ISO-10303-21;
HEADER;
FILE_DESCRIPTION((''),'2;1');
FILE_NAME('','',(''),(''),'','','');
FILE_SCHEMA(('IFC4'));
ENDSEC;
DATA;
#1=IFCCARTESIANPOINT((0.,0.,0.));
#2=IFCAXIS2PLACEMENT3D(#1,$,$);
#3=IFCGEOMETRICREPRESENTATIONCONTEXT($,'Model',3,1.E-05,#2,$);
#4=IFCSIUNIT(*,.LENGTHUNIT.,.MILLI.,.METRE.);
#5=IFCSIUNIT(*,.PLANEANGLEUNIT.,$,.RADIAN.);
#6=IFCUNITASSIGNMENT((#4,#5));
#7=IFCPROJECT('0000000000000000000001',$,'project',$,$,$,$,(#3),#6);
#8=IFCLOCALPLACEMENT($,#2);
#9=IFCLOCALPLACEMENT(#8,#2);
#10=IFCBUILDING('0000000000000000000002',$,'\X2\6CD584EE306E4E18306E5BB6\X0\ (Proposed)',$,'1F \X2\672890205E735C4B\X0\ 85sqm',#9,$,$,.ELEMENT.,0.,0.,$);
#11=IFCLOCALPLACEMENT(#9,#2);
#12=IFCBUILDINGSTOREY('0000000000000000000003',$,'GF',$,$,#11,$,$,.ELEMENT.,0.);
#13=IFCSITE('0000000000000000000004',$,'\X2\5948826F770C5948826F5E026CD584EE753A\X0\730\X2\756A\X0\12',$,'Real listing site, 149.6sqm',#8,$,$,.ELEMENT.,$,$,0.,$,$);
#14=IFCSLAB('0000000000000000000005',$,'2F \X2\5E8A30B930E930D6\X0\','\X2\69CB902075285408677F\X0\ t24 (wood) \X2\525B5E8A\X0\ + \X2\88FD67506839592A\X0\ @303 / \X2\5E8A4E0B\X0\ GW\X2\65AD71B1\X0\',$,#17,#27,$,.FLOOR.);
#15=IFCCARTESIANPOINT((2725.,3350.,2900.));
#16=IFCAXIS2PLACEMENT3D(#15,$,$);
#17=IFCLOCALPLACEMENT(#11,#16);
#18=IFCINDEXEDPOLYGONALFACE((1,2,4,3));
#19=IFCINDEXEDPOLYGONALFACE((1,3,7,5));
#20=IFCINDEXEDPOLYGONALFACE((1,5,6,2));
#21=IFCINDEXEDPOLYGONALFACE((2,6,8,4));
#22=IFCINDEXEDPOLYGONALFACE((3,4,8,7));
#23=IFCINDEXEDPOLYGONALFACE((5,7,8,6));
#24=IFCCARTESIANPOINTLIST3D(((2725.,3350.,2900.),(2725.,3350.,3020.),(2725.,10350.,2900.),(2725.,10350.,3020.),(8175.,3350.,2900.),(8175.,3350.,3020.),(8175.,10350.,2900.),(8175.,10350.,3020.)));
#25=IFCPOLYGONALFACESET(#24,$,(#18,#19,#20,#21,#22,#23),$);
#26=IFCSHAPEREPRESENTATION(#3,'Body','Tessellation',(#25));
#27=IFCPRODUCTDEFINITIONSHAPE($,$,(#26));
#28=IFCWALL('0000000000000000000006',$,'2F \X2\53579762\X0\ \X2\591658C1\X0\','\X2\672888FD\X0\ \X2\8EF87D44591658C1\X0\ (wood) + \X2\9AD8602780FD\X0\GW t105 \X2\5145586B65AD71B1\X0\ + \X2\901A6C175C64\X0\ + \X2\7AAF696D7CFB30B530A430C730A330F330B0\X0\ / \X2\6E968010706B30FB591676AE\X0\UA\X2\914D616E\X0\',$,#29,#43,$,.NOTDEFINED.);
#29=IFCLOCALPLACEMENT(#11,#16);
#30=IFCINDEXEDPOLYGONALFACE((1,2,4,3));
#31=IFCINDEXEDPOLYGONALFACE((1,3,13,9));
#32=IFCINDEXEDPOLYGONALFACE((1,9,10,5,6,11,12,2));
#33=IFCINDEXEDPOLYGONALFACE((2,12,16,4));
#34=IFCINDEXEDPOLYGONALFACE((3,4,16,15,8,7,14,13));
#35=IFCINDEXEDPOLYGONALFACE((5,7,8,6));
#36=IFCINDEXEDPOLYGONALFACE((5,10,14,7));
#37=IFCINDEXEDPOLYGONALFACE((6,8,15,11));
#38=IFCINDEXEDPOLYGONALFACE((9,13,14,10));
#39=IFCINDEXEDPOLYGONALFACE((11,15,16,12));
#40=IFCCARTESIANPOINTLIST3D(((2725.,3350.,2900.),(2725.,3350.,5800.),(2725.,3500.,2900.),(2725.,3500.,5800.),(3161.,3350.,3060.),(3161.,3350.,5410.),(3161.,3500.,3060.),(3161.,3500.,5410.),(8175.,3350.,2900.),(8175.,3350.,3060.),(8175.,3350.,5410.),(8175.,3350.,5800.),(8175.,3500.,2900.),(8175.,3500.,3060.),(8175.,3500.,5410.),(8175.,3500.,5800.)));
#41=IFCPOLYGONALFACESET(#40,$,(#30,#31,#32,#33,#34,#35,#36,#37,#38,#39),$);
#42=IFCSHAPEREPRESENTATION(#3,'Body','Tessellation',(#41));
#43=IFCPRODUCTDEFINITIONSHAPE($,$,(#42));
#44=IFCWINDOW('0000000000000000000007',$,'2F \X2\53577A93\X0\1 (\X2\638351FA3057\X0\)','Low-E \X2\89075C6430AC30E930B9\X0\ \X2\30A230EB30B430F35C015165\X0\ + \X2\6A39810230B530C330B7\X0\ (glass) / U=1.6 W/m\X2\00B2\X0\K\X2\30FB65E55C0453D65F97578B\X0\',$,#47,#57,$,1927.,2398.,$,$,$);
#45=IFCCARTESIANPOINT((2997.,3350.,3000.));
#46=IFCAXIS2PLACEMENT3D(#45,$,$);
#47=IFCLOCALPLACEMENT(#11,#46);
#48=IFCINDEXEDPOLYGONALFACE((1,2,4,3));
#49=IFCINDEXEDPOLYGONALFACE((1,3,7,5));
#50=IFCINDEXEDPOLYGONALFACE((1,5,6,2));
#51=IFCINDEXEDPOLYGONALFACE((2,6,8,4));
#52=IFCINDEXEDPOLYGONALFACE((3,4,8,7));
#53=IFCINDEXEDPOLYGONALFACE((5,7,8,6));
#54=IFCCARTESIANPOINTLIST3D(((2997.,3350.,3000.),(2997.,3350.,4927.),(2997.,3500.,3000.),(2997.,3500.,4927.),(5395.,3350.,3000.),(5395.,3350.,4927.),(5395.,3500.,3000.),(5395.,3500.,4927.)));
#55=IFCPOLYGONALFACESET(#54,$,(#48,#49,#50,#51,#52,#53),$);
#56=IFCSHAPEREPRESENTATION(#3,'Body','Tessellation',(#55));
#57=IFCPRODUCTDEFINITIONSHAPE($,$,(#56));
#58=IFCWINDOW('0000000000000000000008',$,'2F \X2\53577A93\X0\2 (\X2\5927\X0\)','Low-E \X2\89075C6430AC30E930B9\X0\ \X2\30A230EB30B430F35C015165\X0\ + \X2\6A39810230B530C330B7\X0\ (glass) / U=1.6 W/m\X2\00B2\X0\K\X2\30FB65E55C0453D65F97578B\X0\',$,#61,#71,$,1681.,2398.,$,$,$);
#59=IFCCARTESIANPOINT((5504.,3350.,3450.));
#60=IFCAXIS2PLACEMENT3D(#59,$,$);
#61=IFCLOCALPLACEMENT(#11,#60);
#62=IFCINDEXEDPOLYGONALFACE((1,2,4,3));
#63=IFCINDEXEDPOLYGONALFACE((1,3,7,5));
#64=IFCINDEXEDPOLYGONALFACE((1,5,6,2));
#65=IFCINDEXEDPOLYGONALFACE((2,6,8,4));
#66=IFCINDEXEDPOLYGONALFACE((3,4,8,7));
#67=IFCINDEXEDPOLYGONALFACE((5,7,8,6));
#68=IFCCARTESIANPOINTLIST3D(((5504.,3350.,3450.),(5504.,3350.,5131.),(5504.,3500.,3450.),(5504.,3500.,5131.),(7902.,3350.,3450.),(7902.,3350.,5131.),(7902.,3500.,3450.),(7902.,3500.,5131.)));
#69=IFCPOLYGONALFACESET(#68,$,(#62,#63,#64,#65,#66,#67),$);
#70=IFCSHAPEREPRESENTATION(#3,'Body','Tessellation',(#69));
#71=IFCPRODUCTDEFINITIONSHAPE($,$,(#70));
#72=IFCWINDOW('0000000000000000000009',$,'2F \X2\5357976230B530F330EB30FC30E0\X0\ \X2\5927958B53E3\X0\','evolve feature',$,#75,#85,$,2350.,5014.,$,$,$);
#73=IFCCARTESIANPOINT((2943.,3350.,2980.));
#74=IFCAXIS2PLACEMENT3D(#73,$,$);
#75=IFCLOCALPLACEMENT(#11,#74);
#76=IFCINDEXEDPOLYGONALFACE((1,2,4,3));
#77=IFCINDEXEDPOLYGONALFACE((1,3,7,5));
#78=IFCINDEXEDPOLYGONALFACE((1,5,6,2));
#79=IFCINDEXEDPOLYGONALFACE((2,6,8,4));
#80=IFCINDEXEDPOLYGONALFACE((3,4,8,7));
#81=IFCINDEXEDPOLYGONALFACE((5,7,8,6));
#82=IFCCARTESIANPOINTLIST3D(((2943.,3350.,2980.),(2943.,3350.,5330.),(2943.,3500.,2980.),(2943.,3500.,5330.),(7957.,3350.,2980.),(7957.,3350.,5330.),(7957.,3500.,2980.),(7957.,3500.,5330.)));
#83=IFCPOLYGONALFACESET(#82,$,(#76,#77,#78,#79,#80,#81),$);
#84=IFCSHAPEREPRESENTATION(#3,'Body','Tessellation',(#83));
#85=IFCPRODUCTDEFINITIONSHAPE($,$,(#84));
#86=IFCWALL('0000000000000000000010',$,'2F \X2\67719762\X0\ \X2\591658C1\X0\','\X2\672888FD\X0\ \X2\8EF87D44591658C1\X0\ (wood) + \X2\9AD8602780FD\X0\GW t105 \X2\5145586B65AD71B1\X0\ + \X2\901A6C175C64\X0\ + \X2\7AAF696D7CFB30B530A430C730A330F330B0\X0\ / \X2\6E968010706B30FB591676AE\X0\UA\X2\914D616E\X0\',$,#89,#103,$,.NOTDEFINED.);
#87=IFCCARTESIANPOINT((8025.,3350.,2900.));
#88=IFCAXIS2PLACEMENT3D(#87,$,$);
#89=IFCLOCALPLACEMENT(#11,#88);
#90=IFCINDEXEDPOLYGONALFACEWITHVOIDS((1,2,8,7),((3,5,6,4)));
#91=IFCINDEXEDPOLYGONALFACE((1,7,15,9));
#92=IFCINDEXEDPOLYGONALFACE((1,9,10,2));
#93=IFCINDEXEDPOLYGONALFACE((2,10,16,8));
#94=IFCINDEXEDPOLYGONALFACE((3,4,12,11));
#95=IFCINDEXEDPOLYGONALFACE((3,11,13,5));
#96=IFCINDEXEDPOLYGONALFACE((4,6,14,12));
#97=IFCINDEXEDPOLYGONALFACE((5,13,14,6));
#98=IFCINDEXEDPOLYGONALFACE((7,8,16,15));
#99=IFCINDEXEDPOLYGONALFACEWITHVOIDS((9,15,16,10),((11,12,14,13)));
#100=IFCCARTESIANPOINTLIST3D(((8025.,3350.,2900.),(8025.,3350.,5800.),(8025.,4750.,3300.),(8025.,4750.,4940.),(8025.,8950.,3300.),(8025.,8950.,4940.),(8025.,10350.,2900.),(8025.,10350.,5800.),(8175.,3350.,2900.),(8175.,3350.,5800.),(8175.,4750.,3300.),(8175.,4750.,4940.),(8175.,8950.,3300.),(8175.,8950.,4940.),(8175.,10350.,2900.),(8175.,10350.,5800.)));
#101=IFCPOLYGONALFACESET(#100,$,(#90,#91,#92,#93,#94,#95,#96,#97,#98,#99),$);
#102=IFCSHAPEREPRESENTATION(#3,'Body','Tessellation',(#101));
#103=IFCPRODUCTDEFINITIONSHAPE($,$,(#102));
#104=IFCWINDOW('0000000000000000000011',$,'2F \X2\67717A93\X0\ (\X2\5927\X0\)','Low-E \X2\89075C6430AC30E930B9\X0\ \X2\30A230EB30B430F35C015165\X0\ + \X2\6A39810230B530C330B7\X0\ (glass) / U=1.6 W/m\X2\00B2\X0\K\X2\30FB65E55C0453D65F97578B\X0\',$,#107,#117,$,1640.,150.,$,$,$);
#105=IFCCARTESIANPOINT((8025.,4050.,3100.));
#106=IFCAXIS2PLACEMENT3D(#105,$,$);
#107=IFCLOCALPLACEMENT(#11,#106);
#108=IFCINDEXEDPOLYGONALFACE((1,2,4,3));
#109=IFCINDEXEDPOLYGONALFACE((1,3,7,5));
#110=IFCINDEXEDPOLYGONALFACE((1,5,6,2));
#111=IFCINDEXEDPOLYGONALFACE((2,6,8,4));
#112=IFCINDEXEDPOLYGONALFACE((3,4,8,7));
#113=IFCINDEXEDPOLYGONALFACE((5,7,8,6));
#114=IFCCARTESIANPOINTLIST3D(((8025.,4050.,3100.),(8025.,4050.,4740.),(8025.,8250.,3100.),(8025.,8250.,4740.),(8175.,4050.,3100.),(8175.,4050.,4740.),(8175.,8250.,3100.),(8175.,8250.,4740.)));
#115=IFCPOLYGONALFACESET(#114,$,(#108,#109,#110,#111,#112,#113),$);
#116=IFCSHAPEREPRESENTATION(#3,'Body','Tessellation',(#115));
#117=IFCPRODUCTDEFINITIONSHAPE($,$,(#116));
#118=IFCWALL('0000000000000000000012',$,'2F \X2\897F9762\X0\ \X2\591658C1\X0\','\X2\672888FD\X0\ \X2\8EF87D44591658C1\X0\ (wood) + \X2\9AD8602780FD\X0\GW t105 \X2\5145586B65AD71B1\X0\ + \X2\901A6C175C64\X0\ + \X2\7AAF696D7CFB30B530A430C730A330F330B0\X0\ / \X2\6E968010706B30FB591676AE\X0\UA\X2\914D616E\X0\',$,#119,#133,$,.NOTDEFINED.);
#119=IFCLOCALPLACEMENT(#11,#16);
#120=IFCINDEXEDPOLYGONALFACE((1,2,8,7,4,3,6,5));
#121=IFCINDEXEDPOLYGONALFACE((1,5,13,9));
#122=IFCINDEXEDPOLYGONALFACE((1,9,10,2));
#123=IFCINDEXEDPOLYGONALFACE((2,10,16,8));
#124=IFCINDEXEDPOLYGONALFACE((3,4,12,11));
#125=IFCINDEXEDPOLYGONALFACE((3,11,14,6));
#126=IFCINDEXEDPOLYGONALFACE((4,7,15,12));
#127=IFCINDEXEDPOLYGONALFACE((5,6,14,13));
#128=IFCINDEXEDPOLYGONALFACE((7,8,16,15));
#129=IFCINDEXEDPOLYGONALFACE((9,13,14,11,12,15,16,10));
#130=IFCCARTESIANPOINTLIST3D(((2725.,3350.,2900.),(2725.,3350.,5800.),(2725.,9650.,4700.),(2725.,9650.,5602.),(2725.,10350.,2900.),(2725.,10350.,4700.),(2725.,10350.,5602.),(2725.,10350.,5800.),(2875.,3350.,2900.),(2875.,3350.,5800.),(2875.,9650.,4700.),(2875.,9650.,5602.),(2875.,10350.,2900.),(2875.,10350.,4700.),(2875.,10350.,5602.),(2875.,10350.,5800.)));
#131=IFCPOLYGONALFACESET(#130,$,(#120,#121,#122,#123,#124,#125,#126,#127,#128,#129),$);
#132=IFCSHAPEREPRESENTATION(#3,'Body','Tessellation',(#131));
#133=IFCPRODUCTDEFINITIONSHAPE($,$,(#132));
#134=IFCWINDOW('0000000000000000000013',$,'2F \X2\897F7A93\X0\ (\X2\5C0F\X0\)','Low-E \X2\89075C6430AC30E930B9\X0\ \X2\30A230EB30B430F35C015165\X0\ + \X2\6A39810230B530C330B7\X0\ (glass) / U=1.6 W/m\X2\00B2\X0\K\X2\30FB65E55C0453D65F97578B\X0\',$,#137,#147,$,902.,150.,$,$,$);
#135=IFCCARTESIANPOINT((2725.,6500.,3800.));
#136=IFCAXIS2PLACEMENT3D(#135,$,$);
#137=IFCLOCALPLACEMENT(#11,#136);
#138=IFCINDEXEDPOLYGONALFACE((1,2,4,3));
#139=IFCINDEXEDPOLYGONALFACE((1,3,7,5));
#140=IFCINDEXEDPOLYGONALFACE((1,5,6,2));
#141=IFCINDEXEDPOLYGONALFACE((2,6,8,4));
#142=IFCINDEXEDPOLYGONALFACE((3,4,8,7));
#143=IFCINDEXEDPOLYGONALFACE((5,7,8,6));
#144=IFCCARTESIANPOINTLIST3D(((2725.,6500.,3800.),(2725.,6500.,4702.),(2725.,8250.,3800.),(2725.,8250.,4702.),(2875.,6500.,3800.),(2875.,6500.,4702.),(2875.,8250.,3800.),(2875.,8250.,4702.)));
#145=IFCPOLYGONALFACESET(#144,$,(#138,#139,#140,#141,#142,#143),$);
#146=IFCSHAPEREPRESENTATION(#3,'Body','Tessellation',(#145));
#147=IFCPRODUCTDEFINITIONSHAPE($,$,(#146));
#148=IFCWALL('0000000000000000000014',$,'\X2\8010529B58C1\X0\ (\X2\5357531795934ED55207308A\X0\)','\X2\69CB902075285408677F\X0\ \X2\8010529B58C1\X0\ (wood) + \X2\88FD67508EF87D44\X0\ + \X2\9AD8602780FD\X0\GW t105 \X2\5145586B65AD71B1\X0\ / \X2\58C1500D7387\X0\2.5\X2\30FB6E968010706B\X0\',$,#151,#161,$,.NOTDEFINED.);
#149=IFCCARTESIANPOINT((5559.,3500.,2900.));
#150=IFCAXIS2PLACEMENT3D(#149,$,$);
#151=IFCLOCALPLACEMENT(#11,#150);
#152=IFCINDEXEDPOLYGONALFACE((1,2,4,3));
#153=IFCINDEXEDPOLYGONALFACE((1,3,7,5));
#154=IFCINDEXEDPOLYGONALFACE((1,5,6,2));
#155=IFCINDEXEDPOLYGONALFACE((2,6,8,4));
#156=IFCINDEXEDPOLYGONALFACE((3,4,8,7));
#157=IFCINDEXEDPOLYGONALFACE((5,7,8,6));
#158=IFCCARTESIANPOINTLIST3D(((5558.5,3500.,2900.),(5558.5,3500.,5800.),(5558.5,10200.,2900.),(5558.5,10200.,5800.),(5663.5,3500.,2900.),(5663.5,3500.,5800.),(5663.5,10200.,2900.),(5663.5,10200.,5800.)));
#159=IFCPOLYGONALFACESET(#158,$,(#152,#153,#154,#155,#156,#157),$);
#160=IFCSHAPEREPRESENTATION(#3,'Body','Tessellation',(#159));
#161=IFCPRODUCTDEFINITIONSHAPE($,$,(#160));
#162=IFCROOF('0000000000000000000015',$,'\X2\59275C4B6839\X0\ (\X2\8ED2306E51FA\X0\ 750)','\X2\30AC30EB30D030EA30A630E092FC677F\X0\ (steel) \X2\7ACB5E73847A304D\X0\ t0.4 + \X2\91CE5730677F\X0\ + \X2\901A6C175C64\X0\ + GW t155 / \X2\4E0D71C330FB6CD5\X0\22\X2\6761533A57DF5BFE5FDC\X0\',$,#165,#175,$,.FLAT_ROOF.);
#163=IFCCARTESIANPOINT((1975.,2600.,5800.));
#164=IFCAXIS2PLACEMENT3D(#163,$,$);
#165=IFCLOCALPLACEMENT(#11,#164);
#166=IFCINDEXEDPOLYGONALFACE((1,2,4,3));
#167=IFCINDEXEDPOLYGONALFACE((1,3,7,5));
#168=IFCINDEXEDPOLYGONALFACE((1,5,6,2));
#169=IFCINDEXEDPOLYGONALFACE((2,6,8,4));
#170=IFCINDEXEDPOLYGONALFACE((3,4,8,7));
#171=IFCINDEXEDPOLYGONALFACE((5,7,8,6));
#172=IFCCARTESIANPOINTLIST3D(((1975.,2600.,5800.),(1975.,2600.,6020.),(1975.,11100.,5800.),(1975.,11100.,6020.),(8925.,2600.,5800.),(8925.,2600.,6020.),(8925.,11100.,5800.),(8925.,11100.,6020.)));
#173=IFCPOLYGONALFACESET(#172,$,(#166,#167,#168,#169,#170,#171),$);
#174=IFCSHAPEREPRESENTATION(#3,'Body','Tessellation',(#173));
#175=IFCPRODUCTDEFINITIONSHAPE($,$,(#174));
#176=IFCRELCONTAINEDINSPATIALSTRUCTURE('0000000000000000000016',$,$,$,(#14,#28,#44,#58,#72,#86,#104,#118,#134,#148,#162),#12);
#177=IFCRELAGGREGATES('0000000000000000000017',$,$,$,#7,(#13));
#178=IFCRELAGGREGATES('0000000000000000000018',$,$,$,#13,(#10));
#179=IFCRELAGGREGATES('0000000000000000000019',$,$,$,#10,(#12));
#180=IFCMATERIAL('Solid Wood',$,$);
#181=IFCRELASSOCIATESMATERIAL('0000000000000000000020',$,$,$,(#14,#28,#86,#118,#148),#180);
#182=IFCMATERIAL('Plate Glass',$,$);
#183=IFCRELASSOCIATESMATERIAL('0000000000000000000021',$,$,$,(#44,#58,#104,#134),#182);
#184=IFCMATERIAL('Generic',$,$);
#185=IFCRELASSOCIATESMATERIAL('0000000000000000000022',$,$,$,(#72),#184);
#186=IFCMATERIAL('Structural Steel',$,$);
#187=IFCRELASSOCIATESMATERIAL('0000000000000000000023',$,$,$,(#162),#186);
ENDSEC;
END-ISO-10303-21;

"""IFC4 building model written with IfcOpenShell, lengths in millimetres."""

from ifc_helpers import new_model, si_unit, frame, frame_2d, origin, place, context, project, spatial, rectangle, extrude, material, element, fill, save


model = new_model("IFC4")

# Units and contexts
model_context = context("Model", 3, precision=1e-05, world=origin())
ifc_project = project(units=[si_unit("LENGTHUNIT", "METRE", prefix="MILLI"), si_unit("PLANEANGLEUNIT", "RADIAN")], contexts=[model_context])

# Site, building, storey
site_placement = place(None, origin())
site = spatial("IfcSite", under=ifc_project, at=site_placement, Name="奈良県奈良市法蓮町730番12", ObjectType="Real listing site, 149.6sqm", CompositionType="ELEMENT", RefElevation=0.0)
building_placement = place(site_placement, origin())
building = spatial("IfcBuilding", under=site, at=building_placement, Name="法蓮の丘の家 (Proposed)", ObjectType="1F 木造平屋 85sqm", CompositionType="ELEMENT", ElevationOfRefHeight=0.0, ElevationOfTerrain=0.0)
storey_placement = place(building_placement, origin())
storey = spatial("IfcBuildingStorey", under=building, at=storey_placement, Name="GF", CompositionType="ELEMENT", Elevation=0.0)

# Slab
ifc_material_1 = material(Name="Solid Wood")
slab_placement = place(storey_placement, frame((2725.0, 3350.0, 2900.0)))
element("IfcSlab", 1, at=slab_placement, inside=storey, material=ifc_material_1, Name="2F 床スラブ", Description="構造用合板 t24 (wood) 剛床 + 製材根太 @303 / 床下 GW断熱", PredefinedType="FLOOR", context=model_context, shape_type="SweptSolid", body=[
    extrude(rectangle(XDim=5450.0, YDim=7000.0, at=frame_2d((2725.0, 3500.0))), frame((2725.0, 3350.0, 2900.0)), (0.0, 0.0, 1.0), 120.0),
])

# Wall, openings, windows
wall_1_placement = place(storey_placement, frame((2725.0, 3350.0, 2900.0)))
wall_1 = element("IfcWall", 2, at=wall_1_placement, inside=storey, material=ifc_material_1, Name="2F 南面 外壁", Description="木製 軸組外壁 (wood) + 高性能GW t105 充填断熱 + 通気層 + 窯業系サイディング / 準耐火・外皮UA配慮", PredefinedType="NOTDEFINED", context=model_context, shape_type="SweptSolid", body=[
    extrude(rectangle(XDim=5450.0, YDim=150.0, at=frame_2d((2725.0, 75.0))), frame((2725.0, 3350.0, 2900.0)), (0.0, 0.0, 1.0), 2900.0),
])
opening_1_placement = place(storey_placement, frame((2997.0, 3350.0, 3000.0)))
opening_1 = element("IfcOpeningElement", 3, at=opening_1_placement, cuts=wall_1, PredefinedType="NOTDEFINED", context=model_context, shape_type="SweptSolid", body=[
    extrude(rectangle(XDim=2398.0, YDim=150.0, at=frame_2d((1199.0, 75.0))), frame((2997.0, 3350.0, 3000.0)), (0.0, 0.0, 1.0), 1927.0),
])
opening_2_placement = place(storey_placement, frame((5504.0, 3350.0, 3450.0)))
opening_2 = element("IfcOpeningElement", 4, at=opening_2_placement, cuts=wall_1, PredefinedType="NOTDEFINED", context=model_context, shape_type="SweptSolid", body=[
    extrude(rectangle(XDim=2398.0, YDim=150.0, at=frame_2d((1199.0, 75.0))), frame((5504.0, 3350.0, 3450.0)), (0.0, 0.0, 1.0), 1681.0),
])
opening_3_placement = place(storey_placement, frame((2943.0, 3350.0, 2980.0)))
opening_3 = element("IfcOpeningElement", 5, at=opening_3_placement, cuts=wall_1, PredefinedType="NOTDEFINED", context=model_context, shape_type="SweptSolid", body=[
    extrude(rectangle(XDim=5014.0, YDim=150.0, at=frame_2d((2507.0, 75.0))), frame((2943.0, 3350.0, 2980.0)), (0.0, 0.0, 1.0), 2350.0),
])
ifc_material_2 = material(Name="Plate Glass")
window_1_placement = place(storey_placement, frame((2997.0, 3350.0, 3000.0)))
window_1 = element("IfcWindow", 6, at=window_1_placement, inside=storey, material=ifc_material_2, Name="2F 南窓1 (掃出し)", Description="Low-E 複層ガラス アルゴン封入 + 樹脂サッシ (glass) / U=1.6 W/m²K・日射取得型", OverallHeight=1927.0, OverallWidth=2398.0, context=model_context, shape_type="SweptSolid", body=[
    extrude(rectangle(XDim=2398.0, YDim=150.0, at=frame_2d((1199.0, 75.0))), frame((2997.0, 3350.0, 3000.0)), (0.0, 0.0, 1.0), 1927.0),
])
fill(opening_1, window_1)
window_2_placement = place(storey_placement, frame((5504.0, 3350.0, 3450.0)))
window_2 = element("IfcWindow", 7, at=window_2_placement, inside=storey, material=ifc_material_2, Name="2F 南窓2 (大)", Description="Low-E 複層ガラス アルゴン封入 + 樹脂サッシ (glass) / U=1.6 W/m²K・日射取得型", OverallHeight=1681.0, OverallWidth=2398.0, context=model_context, shape_type="SweptSolid", body=[
    extrude(rectangle(XDim=2398.0, YDim=150.0, at=frame_2d((1199.0, 75.0))), frame((5504.0, 3350.0, 3450.0)), (0.0, 0.0, 1.0), 1681.0),
])
fill(opening_2, window_2)
ifc_material_3 = material(Name="Generic")
window_3_placement = place(storey_placement, frame((2943.0, 3350.0, 2980.0)))
window_3 = element("IfcWindow", 8, at=window_3_placement, inside=storey, material=ifc_material_3, Name="2F 南面サンルーム 大開口", Description="evolve feature", OverallHeight=2350.0, OverallWidth=5014.0, context=model_context, shape_type="SweptSolid", body=[
    extrude(rectangle(XDim=5014.0, YDim=150.0, at=frame_2d((2507.0, 75.0))), frame((2943.0, 3350.0, 2980.0)), (0.0, 0.0, 1.0), 2350.0),
])
fill(opening_3, window_3)

# Walls, openings, windows
wall_2_placement = place(storey_placement, frame((8025.0, 3350.0, 2900.0)))
wall_2 = element("IfcWall", 9, at=wall_2_placement, inside=storey, material=ifc_material_1, Name="2F 東面 外壁", Description="木製 軸組外壁 (wood) + 高性能GW t105 充填断熱 + 通気層 + 窯業系サイディング / 準耐火・外皮UA配慮", PredefinedType="NOTDEFINED", context=model_context, shape_type="SweptSolid", body=[
    extrude(rectangle(XDim=150.0, YDim=7000.0, at=frame_2d((75.0, 3500.0))), frame((8025.0, 3350.0, 2900.0)), (0.0, 0.0, 1.0), 2900.0),
])
opening_4_placement = place(storey_placement, frame((8025.0, 4050.0, 3100.0)))
opening_4 = element("IfcOpeningElement", 10, at=opening_4_placement, cuts=wall_2, PredefinedType="NOTDEFINED", context=model_context, shape_type="SweptSolid", body=[
    extrude(rectangle(XDim=150.0, YDim=4200.0, at=frame_2d((75.0, 2100.0))), frame((8025.0, 4050.0, 3100.0)), (0.0, 0.0, 1.0), 1640.0),
])
window_4_placement = place(storey_placement, frame((8025.0, 4050.0, 3100.0)))
window_4 = element("IfcWindow", 11, at=window_4_placement, inside=storey, material=ifc_material_2, Name="2F 東窓 (大)", Description="Low-E 複層ガラス アルゴン封入 + 樹脂サッシ (glass) / U=1.6 W/m²K・日射取得型", OverallHeight=1640.0, OverallWidth=150.0, context=model_context, shape_type="SweptSolid", body=[
    extrude(rectangle(XDim=150.0, YDim=4200.0, at=frame_2d((75.0, 2100.0))), frame((8025.0, 4050.0, 3100.0)), (0.0, 0.0, 1.0), 1640.0),
])
fill(opening_4, window_4)
wall_3_placement = place(storey_placement, frame((2725.0, 3350.0, 2900.0)))
wall_3 = element("IfcWall", 12, at=wall_3_placement, inside=storey, material=ifc_material_1, Name="2F 西面 外壁", Description="木製 軸組外壁 (wood) + 高性能GW t105 充填断熱 + 通気層 + 窯業系サイディング / 準耐火・外皮UA配慮", PredefinedType="NOTDEFINED", context=model_context, shape_type="SweptSolid", body=[
    extrude(rectangle(XDim=150.0, YDim=7000.0, at=frame_2d((75.0, 3500.0))), frame((2725.0, 3350.0, 2900.0)), (0.0, 0.0, 1.0), 2900.0),
])
opening_5_placement = place(storey_placement, frame((2725.0, 6500.0, 3800.0)))
opening_5 = element("IfcOpeningElement", 13, at=opening_5_placement, cuts=wall_3, PredefinedType="NOTDEFINED", context=model_context, shape_type="SweptSolid", body=[
    extrude(rectangle(XDim=150.0, YDim=1750.0, at=frame_2d((75.0, 875.0))), frame((2725.0, 6500.0, 3800.0)), (0.0, 0.0, 1.0), 902.0),
])
window_5_placement = place(storey_placement, frame((2725.0, 6500.0, 3800.0)))
window_5 = element("IfcWindow", 14, at=window_5_placement, inside=storey, material=ifc_material_2, Name="2F 西窓 (小)", Description="Low-E 複層ガラス アルゴン封入 + 樹脂サッシ (glass) / U=1.6 W/m²K・日射取得型", OverallHeight=902.0, OverallWidth=150.0, context=model_context, shape_type="SweptSolid", body=[
    extrude(rectangle(XDim=150.0, YDim=1750.0, at=frame_2d((75.0, 875.0))), frame((2725.0, 6500.0, 3800.0)), (0.0, 0.0, 1.0), 902.0),
])
fill(opening_5, window_5)

# Wall
wall_4_placement = place(storey_placement, frame((5559.0, 3500.0, 2900.0)))
element("IfcWall", 15, at=wall_4_placement, inside=storey, material=ifc_material_1, Name="耐力壁 (南北間仕切り)", Description="構造用合板 耐力壁 (wood) + 製材軸組 + 高性能GW t105 充填断熱 / 壁倍率2.5・準耐火", PredefinedType="NOTDEFINED", context=model_context, shape_type="SweptSolid", body=[
    extrude(rectangle(XDim=105.0, YDim=6700.0, at=frame_2d((52.0, 3350.0))), frame((5559.0, 3500.0, 2900.0)), (0.0, 0.0, 1.0), 2900.0),
])

# Roof
ifc_material_4 = material(Name="Structural Steel")
roof_placement = place(storey_placement, frame((1975.0, 2600.0, 5800.0)))
element("IfcRoof", 16, at=roof_placement, inside=storey, material=ifc_material_4, Name="大屋根 (軒の出 750)", Description="ガルバリウム鋼板 (steel) 立平葺き t0.4 + 野地板 + 通気層 + GW t155 / 不燃・法22条区域対応", PredefinedType="FLAT_ROOF", context=model_context, shape_type="SweptSolid", body=[
    extrude(rectangle(XDim=6950.0, YDim=8500.0, at=frame_2d((3475.0, 4250.0))), frame((1975.0, 2600.0, 5800.0)), (0.0, 0.0, 1.0), 220.0),
])

save(model, "model.ifc")
